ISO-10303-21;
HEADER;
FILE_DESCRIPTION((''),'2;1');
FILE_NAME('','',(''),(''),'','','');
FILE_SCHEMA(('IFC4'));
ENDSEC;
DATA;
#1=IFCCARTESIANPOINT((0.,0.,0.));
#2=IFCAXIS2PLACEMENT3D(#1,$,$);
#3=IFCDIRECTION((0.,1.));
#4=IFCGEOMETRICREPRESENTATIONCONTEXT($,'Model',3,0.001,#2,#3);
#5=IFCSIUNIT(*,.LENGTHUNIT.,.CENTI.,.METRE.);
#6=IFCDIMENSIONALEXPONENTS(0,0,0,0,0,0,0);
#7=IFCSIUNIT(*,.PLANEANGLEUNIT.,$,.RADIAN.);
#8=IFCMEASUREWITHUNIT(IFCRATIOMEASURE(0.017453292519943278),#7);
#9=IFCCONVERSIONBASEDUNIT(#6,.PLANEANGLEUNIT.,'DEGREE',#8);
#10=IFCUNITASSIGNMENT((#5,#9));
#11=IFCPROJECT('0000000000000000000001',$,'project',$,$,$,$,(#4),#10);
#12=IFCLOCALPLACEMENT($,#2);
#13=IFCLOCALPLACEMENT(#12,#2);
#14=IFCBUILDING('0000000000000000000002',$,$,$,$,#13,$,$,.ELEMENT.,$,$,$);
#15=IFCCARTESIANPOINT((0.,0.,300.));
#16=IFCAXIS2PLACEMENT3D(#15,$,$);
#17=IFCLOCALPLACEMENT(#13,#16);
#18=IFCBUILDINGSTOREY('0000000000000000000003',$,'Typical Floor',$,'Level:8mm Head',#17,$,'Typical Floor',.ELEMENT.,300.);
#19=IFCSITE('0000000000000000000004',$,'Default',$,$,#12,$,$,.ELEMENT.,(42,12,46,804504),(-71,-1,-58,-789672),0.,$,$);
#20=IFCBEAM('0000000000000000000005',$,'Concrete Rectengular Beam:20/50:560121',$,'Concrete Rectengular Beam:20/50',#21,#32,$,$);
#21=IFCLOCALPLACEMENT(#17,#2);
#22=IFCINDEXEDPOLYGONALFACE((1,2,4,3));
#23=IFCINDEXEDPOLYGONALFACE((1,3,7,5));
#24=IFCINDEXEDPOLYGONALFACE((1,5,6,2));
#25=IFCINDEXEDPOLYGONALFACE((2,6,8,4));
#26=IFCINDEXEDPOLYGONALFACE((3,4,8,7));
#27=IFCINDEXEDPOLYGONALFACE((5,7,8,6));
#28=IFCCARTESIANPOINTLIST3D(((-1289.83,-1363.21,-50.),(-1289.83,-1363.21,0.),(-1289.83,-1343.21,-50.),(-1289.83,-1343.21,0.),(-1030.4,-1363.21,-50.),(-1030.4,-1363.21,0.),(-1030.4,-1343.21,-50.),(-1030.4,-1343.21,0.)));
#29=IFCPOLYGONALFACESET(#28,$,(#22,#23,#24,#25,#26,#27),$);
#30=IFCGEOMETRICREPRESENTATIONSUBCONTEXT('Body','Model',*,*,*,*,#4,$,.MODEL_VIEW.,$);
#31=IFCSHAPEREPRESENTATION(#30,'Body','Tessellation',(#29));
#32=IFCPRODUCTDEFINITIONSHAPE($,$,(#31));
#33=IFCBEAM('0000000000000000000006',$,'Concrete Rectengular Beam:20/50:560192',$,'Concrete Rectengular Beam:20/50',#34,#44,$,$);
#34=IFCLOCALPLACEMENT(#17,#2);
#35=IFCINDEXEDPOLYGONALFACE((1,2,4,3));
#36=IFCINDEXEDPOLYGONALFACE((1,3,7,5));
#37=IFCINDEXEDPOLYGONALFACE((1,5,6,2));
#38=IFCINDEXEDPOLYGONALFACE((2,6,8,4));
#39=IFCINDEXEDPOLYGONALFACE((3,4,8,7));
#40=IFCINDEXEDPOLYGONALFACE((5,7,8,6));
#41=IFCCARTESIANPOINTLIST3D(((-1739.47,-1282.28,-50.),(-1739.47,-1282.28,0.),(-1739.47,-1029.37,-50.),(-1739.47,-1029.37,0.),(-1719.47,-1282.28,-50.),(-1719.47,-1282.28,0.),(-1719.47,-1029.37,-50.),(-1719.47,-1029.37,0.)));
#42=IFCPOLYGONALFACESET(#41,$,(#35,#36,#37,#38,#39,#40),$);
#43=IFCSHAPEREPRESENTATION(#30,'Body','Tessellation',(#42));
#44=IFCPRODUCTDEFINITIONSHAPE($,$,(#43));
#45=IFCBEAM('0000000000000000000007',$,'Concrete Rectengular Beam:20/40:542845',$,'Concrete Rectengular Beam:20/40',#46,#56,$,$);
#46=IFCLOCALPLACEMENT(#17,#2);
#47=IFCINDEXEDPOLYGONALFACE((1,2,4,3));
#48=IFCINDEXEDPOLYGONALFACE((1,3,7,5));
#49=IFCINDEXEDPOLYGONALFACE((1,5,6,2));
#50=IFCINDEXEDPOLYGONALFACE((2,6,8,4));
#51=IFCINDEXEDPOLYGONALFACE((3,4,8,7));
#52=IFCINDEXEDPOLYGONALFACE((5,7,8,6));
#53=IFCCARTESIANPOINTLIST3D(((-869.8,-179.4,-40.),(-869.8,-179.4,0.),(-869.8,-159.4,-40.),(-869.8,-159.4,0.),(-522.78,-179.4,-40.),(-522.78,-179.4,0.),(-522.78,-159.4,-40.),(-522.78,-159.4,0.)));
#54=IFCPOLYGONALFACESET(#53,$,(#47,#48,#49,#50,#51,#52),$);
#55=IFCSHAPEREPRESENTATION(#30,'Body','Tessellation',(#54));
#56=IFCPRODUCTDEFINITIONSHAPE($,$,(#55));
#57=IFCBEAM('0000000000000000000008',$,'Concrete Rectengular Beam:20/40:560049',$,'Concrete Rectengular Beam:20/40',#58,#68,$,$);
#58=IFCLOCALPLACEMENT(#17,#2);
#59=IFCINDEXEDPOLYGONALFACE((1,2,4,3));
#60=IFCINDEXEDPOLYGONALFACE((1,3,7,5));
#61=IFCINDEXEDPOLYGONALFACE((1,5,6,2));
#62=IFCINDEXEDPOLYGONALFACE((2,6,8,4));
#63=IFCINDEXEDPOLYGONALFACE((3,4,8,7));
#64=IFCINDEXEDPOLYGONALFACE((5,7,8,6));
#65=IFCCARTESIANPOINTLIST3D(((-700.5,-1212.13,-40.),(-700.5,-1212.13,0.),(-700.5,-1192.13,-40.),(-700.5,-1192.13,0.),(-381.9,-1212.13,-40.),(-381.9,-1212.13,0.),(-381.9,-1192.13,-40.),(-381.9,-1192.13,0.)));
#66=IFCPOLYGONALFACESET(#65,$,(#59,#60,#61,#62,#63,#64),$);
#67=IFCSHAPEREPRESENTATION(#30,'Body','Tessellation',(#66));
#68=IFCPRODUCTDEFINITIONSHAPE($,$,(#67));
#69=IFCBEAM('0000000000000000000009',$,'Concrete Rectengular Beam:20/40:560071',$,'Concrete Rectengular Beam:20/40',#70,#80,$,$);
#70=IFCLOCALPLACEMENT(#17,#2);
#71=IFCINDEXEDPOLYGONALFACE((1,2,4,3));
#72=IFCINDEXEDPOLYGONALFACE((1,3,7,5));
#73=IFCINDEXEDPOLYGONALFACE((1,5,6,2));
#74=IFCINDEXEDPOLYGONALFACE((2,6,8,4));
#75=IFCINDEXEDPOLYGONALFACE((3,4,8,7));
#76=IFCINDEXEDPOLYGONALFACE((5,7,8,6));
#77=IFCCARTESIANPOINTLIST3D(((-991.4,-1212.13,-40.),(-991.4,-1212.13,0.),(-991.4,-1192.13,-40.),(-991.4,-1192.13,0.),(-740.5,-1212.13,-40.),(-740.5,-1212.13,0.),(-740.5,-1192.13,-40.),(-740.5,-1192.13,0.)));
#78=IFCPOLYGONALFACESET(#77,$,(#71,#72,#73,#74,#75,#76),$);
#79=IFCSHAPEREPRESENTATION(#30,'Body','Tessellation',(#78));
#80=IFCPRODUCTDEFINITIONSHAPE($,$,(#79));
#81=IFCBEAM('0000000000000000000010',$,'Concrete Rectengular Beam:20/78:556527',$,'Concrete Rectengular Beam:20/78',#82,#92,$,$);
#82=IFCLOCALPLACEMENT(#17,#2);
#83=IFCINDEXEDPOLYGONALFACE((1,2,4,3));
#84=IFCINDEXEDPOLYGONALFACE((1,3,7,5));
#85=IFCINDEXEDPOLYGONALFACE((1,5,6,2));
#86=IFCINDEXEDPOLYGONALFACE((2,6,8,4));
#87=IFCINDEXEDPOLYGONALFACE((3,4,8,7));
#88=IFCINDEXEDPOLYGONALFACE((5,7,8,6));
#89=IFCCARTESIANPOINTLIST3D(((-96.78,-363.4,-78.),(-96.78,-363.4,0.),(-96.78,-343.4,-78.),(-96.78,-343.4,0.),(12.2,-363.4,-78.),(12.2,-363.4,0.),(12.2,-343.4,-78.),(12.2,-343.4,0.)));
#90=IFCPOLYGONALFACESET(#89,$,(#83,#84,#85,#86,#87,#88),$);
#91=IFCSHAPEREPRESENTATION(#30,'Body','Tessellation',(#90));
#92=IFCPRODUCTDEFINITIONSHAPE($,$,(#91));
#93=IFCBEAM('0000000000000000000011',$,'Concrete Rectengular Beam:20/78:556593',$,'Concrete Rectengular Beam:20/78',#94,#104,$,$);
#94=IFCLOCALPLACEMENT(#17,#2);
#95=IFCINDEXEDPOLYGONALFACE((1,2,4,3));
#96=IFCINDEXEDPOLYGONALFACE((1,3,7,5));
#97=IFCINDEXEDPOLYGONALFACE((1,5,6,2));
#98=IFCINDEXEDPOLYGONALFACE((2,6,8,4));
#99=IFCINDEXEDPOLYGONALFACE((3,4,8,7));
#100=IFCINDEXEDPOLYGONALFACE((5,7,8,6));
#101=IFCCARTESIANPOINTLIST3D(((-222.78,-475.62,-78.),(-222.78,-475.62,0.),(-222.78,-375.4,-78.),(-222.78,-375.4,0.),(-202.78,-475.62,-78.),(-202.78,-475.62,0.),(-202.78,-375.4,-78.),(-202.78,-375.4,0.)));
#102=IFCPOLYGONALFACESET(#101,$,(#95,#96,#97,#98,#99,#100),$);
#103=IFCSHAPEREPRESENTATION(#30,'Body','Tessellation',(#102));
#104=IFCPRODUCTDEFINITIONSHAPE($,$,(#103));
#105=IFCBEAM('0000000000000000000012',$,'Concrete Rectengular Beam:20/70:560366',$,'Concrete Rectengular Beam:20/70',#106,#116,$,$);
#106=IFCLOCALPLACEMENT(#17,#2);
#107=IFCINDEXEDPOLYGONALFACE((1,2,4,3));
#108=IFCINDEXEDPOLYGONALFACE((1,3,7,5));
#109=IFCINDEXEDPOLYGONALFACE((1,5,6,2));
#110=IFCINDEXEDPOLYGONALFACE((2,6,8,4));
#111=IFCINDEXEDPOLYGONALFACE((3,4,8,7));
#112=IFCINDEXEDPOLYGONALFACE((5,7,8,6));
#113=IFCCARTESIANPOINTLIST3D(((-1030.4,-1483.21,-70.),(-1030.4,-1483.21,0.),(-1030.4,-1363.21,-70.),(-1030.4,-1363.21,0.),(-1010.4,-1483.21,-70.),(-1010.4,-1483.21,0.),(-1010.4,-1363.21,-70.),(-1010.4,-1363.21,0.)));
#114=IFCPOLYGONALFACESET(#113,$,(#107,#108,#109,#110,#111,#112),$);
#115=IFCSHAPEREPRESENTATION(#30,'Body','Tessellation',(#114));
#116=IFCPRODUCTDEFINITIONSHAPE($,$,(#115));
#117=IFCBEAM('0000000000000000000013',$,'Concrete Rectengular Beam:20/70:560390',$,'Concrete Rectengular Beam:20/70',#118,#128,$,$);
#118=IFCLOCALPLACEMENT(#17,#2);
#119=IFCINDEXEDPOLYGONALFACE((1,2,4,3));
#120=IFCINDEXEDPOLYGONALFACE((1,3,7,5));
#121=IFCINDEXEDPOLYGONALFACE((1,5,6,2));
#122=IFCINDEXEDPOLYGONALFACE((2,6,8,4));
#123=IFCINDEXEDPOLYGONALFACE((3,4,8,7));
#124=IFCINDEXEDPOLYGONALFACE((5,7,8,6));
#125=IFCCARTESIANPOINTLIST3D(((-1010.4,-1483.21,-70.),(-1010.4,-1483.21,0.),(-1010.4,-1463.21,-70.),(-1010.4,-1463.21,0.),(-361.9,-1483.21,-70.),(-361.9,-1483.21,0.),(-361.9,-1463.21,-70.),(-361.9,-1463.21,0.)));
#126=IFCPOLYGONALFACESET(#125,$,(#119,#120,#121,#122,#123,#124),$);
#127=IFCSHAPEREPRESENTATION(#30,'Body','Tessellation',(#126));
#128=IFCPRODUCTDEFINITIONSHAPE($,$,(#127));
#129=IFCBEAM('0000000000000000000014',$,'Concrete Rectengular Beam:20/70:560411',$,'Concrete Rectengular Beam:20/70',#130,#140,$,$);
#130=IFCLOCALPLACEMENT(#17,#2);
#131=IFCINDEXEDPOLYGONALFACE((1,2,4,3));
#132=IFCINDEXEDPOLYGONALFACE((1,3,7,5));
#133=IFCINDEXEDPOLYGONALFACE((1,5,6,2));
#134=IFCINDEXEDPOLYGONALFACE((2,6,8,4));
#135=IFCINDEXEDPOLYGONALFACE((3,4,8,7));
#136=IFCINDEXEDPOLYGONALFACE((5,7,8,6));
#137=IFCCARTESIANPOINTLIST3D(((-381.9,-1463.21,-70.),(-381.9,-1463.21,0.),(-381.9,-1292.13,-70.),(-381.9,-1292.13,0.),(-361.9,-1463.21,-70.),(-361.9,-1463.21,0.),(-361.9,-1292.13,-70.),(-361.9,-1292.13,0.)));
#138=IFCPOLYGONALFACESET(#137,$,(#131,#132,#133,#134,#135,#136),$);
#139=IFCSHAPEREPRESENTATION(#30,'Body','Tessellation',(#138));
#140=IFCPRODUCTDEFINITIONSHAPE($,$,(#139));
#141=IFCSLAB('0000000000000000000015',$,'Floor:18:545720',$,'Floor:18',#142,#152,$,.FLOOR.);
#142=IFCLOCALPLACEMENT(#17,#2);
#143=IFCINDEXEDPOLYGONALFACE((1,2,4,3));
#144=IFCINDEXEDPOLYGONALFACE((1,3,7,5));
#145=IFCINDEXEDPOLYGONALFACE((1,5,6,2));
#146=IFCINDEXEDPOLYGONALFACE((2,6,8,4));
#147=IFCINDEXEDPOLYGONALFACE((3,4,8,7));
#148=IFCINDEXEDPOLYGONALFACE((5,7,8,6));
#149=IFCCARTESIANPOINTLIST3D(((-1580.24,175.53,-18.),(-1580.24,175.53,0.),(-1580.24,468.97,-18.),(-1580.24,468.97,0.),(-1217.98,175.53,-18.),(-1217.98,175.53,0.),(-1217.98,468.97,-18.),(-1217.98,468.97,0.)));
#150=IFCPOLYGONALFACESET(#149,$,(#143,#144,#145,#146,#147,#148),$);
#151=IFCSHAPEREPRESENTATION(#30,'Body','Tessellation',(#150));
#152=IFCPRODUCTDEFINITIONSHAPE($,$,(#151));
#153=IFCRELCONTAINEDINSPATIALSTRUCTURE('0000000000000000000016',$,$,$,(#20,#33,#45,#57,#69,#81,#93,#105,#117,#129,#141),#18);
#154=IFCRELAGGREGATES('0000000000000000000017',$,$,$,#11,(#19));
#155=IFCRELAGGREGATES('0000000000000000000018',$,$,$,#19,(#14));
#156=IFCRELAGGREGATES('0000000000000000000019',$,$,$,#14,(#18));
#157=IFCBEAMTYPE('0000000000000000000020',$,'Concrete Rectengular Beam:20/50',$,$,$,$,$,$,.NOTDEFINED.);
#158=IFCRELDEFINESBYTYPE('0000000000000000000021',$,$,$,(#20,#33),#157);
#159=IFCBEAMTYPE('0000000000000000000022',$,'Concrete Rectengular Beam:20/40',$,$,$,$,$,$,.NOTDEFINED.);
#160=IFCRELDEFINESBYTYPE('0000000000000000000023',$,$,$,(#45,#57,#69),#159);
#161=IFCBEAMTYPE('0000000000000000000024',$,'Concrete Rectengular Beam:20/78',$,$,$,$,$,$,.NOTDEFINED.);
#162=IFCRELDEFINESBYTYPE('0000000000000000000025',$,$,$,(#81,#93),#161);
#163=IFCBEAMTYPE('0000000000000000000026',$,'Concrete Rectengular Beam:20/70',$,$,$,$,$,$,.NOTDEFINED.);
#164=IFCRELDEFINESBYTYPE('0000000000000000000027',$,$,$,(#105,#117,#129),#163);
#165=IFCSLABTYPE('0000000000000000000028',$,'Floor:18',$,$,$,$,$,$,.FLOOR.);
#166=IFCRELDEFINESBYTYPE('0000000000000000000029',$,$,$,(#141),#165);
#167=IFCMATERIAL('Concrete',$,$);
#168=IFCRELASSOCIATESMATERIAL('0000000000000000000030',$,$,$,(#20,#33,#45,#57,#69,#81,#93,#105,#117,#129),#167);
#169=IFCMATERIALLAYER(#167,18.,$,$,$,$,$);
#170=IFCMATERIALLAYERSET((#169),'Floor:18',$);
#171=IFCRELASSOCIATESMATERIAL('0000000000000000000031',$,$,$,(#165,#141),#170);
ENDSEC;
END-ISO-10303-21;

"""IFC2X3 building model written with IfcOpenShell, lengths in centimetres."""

from ifc_helpers import new_model, entity, si_unit, converted_unit, direction, frame, frame_2d, origin, origin_2d_with_axis, place, context, subcontext, project, spatial, rectangle, extrude, material, layer, layer_set, layer_usage, type_object, element, save


model = new_model("IFC2X3")

# Units and contexts
model_context = context("Model", 3, precision=0.001, world=origin(), true_north=direction((0.0, 1.0)))
body_context = subcontext(model_context, "Body", "Model", "MODEL_VIEW")
ifc_project = project(units=[si_unit("LENGTHUNIT", "METRE", prefix="CENTI"), converted_unit("PLANEANGLEUNIT", "DEGREE", entity("IfcRatioMeasure", 0.017453292519943278), si_unit("PLANEANGLEUNIT", "RADIAN"), dimensions=[0, 0, 0, 0, 0, 0, 0])], contexts=[model_context])

# Site, building, storey
site_placement = place(None, origin())
site = spatial("IfcSite", under=ifc_project, at=site_placement, Name="Default", CompositionType="ELEMENT", RefLatitude=(42, 12, 46, 804504), RefLongitude=(-71, -1, -58, -789672), RefElevation=0.0)
building_placement = place(site_placement, origin())
building = spatial("IfcBuilding", under=site, at=building_placement, CompositionType="ELEMENT")
storey_placement = place(building_placement, frame((0.0, 0.0, 300.0)))
storey = spatial("IfcBuildingStorey", under=building, at=storey_placement, Name="Typical Floor", ObjectType="Level:8mm Head", LongName="Typical Floor", CompositionType="ELEMENT", Elevation=300.0)

# Beams
ifc_material = material(Name="Concrete")
beam_type_1 = type_object("IfcBeamType", Name="Concrete Rectengular Beam:20/50", PredefinedType="NOTDEFINED")
beam_1_placement = place(storey_placement, frame((-1020.4, -1353.21, 0.0), z_axis=(0.0, 0.0, 1.0), x_axis=(-1.0, 0.0, 0.0)))
element("IfcBeam", 1, at=beam_1_placement, inside=storey, type_object=beam_type_1, material=ifc_material, Name="Concrete Rectengular Beam:20/50:560121", ObjectType="Concrete Rectengular Beam:20/50", context=body_context, shape_type="SweptSolid", body=[
    extrude(rectangle(XDim=50.0, YDim=20.0, at=frame_2d((0.0, 0.0), x_axis=(1.0, 0.0))), frame((10.0, 0.0, -25.0), z_axis=(1.0, 0.0, 0.0), x_axis=(0.0, 0.0, -1.0)), (0.0, 0.0, 1.0), 259.44),
])
beam_2_placement = place(storey_placement, frame((-1729.47, -1302.28, 0.0), z_axis=(0.0, 0.0, 1.0), x_axis=(0.0, 1.0, 0.0)))
element("IfcBeam", 2, at=beam_2_placement, inside=storey, type_object=beam_type_1, material=ifc_material, Name="Concrete Rectengular Beam:20/50:560192", ObjectType="Concrete Rectengular Beam:20/50", context=body_context, shape_type="SweptSolid", body=[
    extrude(rectangle(XDim=50.0, YDim=20.0, at=frame_2d((0.0, 0.0), x_axis=(1.0, 0.0))), frame((20.0, 0.0, -25.0), z_axis=(1.0, 0.0, 0.0), x_axis=(0.0, 0.0, -1.0)), (0.0, 0.0, 1.0), 252.91),
])
beam_type_2 = type_object("IfcBeamType", Name="Concrete Rectengular Beam:20/40", PredefinedType="NOTDEFINED")
beam_3_placement = place(storey_placement, frame((-879.8, -169.4, 0.0)))
element("IfcBeam", 3, at=beam_3_placement, inside=storey, type_object=beam_type_2, material=ifc_material, Name="Concrete Rectengular Beam:20/40:542845", ObjectType="Concrete Rectengular Beam:20/40", context=body_context, shape_type="SweptSolid", body=[
    extrude(rectangle(XDim=40.0, YDim=20.0, at=origin_2d_with_axis()), frame((10.0, 0.0, -20.0), z_axis=(1.0, 0.0, 0.0), x_axis=(0.0, 0.0, -1.0)), (0.0, 0.0, 1.0), 347.02),
])
beam_4_placement = place(storey_placement, frame((-371.9, -1202.13, 0.0), z_axis=(0.0, 0.0, 1.0), x_axis=(-1.0, 0.0, 0.0)))
element("IfcBeam", 4, at=beam_4_placement, inside=storey, type_object=beam_type_2, material=ifc_material, Name="Concrete Rectengular Beam:20/40:560049", ObjectType="Concrete Rectengular Beam:20/40", context=body_context, shape_type="SweptSolid", body=[
    extrude(rectangle(XDim=40.0, YDim=20.0, at=frame_2d((0.0, 0.0), x_axis=(1.0, 0.0))), frame((10.0, 0.0, -20.0), z_axis=(1.0, 0.0, 0.0), x_axis=(0.0, 0.0, -1.0)), (0.0, 0.0, 1.0), 318.6),
])
beam_5_placement = place(storey_placement, frame((-720.5, -1202.13, 0.0), z_axis=(0.0, 0.0, 1.0), x_axis=(-1.0, 0.0, 0.0)))
element("IfcBeam", 5, at=beam_5_placement, inside=storey, type_object=beam_type_2, material=ifc_material, Name="Concrete Rectengular Beam:20/40:560071", ObjectType="Concrete Rectengular Beam:20/40", context=body_context, shape_type="SweptSolid", body=[
    extrude(rectangle(XDim=40.0, YDim=20.0, at=frame_2d((0.0, 0.0), x_axis=(1.0, 0.0))), frame((20.0, 0.0, -20.0), z_axis=(1.0, 0.0, 0.0), x_axis=(0.0, 0.0, -1.0)), (0.0, 0.0, 1.0), 250.9),
])
beam_type_3 = type_object("IfcBeamType", Name="Concrete Rectengular Beam:20/78", PredefinedType="NOTDEFINED")
beam_6_placement = place(storey_placement, frame((-96.78, -353.4, 0.0)))
element("IfcBeam", 6, at=beam_6_placement, inside=storey, type_object=beam_type_3, material=ifc_material, Name="Concrete Rectengular Beam:20/78:556527", ObjectType="Concrete Rectengular Beam:20/78", context=body_context, shape_type="SweptSolid", body=[
    extrude(rectangle(XDim=78.0, YDim=20.0, at=frame_2d((0.0, 0.0), x_axis=(1.0, 0.0))), frame((0.0, 0.0, -39.0), z_axis=(1.0, 0.0, 0.0), x_axis=(0.0, 0.0, -1.0)), (0.0, 0.0, 1.0), 108.98),
])
beam_7_placement = place(storey_placement, frame((-212.78, -365.4, 0.0), z_axis=(0.0, 0.0, 1.0), x_axis=(0.0, -1.0, 0.0)))
element("IfcBeam", 7, at=beam_7_placement, inside=storey, type_object=beam_type_3, material=ifc_material, Name="Concrete Rectengular Beam:20/78:556593", ObjectType="Concrete Rectengular Beam:20/78", context=body_context, shape_type="SweptSolid", body=[
    extrude(rectangle(XDim=78.0, YDim=20.0, at=frame_2d((0.0, 0.0), x_axis=(1.0, 0.0))), frame((10.0, 0.0, -39.0), z_axis=(1.0, 0.0, 0.0), x_axis=(0.0, 0.0, -1.0)), (0.0, 0.0, 1.0), 100.22),
])
beam_type_4 = type_object("IfcBeamType", Name="Concrete Rectengular Beam:20/70", PredefinedType="NOTDEFINED")
beam_8_placement = place(storey_placement, frame((-1020.4, -1353.21, 0.0), z_axis=(0.0, 0.0, 1.0), x_axis=(0.0, -1.0, 0.0)))
element("IfcBeam", 8, at=beam_8_placement, inside=storey, type_object=beam_type_4, material=ifc_material, Name="Concrete Rectengular Beam:20/70:560366", ObjectType="Concrete Rectengular Beam:20/70", context=body_context, shape_type="SweptSolid", body=[
    extrude(rectangle(XDim=70.0, YDim=20.0, at=frame_2d((0.0, 0.0), x_axis=(1.0, 0.0))), frame((10.0, 0.0, -35.0), z_axis=(1.0, 0.0, 0.0), x_axis=(0.0, 0.0, -1.0)), (0.0, 0.0, 1.0), 120.0),
])
beam_9_placement = place(storey_placement, frame((-1020.4, -1473.21, 0.0)))
element("IfcBeam", 9, at=beam_9_placement, inside=storey, type_object=beam_type_4, material=ifc_material, Name="Concrete Rectengular Beam:20/70:560390", ObjectType="Concrete Rectengular Beam:20/70", context=body_context, shape_type="SweptSolid", body=[
    extrude(rectangle(XDim=70.0, YDim=20.0, at=frame_2d((0.0, 0.0), x_axis=(1.0, 0.0))), frame((10.0, 0.0, -35.0), z_axis=(1.0, 0.0, 0.0), x_axis=(0.0, 0.0, -1.0)), (0.0, 0.0, 1.0), 648.49),
])
beam_10_placement = place(storey_placement, frame((-371.9, -1473.21, 0.0), z_axis=(0.0, 0.0, 1.0), x_axis=(0.0, 1.0, 0.0)))
element("IfcBeam", 10, at=beam_10_placement, inside=storey, type_object=beam_type_4, material=ifc_material, Name="Concrete Rectengular Beam:20/70:560411", ObjectType="Concrete Rectengular Beam:20/70", context=body_context, shape_type="SweptSolid", body=[
    extrude(rectangle(XDim=70.0, YDim=20.0, at=origin_2d_with_axis()), frame((10.0, 0.0, -35.0), z_axis=(1.0, 0.0, 0.0), x_axis=(0.0, 0.0, -1.0)), (0.0, 0.0, 1.0), 171.08),
])

# Slab
ifc_layer = layer(ifc_material, 18.0)
ifc_layer_set = layer_set([ifc_layer], Name="Floor:18")
ifc_layer_usage_1 = layer_usage(ifc_layer_set, "AXIS3", "POSITIVE", 0.0)
slab_type_1 = type_object("IfcSlabType", Name="Floor:18", PredefinedType="FLOOR", material=ifc_layer_set)
slab_1_placement = place(storey_placement, origin())
element("IfcSlab", 11, at=slab_1_placement, inside=storey, type_object=slab_type_1, material=ifc_layer_usage_1, Name="Floor:18:545720", ObjectType="Floor:18", PredefinedType="FLOOR", context=body_context, shape_type="SweptSolid", body=[
    extrude(rectangle(XDim=293.44, YDim=362.26, at=frame_2d((0.0, 0.0), x_axis=(1.0, 0.0))), frame((-1399.11, 322.25, 0.0), z_axis=(0.0, 0.0, -1.0), x_axis=(0.0, 1.0, 0.0)), (0.0, 0.0, 1.0), 18.0),
])

save(model, "model.ifc")
